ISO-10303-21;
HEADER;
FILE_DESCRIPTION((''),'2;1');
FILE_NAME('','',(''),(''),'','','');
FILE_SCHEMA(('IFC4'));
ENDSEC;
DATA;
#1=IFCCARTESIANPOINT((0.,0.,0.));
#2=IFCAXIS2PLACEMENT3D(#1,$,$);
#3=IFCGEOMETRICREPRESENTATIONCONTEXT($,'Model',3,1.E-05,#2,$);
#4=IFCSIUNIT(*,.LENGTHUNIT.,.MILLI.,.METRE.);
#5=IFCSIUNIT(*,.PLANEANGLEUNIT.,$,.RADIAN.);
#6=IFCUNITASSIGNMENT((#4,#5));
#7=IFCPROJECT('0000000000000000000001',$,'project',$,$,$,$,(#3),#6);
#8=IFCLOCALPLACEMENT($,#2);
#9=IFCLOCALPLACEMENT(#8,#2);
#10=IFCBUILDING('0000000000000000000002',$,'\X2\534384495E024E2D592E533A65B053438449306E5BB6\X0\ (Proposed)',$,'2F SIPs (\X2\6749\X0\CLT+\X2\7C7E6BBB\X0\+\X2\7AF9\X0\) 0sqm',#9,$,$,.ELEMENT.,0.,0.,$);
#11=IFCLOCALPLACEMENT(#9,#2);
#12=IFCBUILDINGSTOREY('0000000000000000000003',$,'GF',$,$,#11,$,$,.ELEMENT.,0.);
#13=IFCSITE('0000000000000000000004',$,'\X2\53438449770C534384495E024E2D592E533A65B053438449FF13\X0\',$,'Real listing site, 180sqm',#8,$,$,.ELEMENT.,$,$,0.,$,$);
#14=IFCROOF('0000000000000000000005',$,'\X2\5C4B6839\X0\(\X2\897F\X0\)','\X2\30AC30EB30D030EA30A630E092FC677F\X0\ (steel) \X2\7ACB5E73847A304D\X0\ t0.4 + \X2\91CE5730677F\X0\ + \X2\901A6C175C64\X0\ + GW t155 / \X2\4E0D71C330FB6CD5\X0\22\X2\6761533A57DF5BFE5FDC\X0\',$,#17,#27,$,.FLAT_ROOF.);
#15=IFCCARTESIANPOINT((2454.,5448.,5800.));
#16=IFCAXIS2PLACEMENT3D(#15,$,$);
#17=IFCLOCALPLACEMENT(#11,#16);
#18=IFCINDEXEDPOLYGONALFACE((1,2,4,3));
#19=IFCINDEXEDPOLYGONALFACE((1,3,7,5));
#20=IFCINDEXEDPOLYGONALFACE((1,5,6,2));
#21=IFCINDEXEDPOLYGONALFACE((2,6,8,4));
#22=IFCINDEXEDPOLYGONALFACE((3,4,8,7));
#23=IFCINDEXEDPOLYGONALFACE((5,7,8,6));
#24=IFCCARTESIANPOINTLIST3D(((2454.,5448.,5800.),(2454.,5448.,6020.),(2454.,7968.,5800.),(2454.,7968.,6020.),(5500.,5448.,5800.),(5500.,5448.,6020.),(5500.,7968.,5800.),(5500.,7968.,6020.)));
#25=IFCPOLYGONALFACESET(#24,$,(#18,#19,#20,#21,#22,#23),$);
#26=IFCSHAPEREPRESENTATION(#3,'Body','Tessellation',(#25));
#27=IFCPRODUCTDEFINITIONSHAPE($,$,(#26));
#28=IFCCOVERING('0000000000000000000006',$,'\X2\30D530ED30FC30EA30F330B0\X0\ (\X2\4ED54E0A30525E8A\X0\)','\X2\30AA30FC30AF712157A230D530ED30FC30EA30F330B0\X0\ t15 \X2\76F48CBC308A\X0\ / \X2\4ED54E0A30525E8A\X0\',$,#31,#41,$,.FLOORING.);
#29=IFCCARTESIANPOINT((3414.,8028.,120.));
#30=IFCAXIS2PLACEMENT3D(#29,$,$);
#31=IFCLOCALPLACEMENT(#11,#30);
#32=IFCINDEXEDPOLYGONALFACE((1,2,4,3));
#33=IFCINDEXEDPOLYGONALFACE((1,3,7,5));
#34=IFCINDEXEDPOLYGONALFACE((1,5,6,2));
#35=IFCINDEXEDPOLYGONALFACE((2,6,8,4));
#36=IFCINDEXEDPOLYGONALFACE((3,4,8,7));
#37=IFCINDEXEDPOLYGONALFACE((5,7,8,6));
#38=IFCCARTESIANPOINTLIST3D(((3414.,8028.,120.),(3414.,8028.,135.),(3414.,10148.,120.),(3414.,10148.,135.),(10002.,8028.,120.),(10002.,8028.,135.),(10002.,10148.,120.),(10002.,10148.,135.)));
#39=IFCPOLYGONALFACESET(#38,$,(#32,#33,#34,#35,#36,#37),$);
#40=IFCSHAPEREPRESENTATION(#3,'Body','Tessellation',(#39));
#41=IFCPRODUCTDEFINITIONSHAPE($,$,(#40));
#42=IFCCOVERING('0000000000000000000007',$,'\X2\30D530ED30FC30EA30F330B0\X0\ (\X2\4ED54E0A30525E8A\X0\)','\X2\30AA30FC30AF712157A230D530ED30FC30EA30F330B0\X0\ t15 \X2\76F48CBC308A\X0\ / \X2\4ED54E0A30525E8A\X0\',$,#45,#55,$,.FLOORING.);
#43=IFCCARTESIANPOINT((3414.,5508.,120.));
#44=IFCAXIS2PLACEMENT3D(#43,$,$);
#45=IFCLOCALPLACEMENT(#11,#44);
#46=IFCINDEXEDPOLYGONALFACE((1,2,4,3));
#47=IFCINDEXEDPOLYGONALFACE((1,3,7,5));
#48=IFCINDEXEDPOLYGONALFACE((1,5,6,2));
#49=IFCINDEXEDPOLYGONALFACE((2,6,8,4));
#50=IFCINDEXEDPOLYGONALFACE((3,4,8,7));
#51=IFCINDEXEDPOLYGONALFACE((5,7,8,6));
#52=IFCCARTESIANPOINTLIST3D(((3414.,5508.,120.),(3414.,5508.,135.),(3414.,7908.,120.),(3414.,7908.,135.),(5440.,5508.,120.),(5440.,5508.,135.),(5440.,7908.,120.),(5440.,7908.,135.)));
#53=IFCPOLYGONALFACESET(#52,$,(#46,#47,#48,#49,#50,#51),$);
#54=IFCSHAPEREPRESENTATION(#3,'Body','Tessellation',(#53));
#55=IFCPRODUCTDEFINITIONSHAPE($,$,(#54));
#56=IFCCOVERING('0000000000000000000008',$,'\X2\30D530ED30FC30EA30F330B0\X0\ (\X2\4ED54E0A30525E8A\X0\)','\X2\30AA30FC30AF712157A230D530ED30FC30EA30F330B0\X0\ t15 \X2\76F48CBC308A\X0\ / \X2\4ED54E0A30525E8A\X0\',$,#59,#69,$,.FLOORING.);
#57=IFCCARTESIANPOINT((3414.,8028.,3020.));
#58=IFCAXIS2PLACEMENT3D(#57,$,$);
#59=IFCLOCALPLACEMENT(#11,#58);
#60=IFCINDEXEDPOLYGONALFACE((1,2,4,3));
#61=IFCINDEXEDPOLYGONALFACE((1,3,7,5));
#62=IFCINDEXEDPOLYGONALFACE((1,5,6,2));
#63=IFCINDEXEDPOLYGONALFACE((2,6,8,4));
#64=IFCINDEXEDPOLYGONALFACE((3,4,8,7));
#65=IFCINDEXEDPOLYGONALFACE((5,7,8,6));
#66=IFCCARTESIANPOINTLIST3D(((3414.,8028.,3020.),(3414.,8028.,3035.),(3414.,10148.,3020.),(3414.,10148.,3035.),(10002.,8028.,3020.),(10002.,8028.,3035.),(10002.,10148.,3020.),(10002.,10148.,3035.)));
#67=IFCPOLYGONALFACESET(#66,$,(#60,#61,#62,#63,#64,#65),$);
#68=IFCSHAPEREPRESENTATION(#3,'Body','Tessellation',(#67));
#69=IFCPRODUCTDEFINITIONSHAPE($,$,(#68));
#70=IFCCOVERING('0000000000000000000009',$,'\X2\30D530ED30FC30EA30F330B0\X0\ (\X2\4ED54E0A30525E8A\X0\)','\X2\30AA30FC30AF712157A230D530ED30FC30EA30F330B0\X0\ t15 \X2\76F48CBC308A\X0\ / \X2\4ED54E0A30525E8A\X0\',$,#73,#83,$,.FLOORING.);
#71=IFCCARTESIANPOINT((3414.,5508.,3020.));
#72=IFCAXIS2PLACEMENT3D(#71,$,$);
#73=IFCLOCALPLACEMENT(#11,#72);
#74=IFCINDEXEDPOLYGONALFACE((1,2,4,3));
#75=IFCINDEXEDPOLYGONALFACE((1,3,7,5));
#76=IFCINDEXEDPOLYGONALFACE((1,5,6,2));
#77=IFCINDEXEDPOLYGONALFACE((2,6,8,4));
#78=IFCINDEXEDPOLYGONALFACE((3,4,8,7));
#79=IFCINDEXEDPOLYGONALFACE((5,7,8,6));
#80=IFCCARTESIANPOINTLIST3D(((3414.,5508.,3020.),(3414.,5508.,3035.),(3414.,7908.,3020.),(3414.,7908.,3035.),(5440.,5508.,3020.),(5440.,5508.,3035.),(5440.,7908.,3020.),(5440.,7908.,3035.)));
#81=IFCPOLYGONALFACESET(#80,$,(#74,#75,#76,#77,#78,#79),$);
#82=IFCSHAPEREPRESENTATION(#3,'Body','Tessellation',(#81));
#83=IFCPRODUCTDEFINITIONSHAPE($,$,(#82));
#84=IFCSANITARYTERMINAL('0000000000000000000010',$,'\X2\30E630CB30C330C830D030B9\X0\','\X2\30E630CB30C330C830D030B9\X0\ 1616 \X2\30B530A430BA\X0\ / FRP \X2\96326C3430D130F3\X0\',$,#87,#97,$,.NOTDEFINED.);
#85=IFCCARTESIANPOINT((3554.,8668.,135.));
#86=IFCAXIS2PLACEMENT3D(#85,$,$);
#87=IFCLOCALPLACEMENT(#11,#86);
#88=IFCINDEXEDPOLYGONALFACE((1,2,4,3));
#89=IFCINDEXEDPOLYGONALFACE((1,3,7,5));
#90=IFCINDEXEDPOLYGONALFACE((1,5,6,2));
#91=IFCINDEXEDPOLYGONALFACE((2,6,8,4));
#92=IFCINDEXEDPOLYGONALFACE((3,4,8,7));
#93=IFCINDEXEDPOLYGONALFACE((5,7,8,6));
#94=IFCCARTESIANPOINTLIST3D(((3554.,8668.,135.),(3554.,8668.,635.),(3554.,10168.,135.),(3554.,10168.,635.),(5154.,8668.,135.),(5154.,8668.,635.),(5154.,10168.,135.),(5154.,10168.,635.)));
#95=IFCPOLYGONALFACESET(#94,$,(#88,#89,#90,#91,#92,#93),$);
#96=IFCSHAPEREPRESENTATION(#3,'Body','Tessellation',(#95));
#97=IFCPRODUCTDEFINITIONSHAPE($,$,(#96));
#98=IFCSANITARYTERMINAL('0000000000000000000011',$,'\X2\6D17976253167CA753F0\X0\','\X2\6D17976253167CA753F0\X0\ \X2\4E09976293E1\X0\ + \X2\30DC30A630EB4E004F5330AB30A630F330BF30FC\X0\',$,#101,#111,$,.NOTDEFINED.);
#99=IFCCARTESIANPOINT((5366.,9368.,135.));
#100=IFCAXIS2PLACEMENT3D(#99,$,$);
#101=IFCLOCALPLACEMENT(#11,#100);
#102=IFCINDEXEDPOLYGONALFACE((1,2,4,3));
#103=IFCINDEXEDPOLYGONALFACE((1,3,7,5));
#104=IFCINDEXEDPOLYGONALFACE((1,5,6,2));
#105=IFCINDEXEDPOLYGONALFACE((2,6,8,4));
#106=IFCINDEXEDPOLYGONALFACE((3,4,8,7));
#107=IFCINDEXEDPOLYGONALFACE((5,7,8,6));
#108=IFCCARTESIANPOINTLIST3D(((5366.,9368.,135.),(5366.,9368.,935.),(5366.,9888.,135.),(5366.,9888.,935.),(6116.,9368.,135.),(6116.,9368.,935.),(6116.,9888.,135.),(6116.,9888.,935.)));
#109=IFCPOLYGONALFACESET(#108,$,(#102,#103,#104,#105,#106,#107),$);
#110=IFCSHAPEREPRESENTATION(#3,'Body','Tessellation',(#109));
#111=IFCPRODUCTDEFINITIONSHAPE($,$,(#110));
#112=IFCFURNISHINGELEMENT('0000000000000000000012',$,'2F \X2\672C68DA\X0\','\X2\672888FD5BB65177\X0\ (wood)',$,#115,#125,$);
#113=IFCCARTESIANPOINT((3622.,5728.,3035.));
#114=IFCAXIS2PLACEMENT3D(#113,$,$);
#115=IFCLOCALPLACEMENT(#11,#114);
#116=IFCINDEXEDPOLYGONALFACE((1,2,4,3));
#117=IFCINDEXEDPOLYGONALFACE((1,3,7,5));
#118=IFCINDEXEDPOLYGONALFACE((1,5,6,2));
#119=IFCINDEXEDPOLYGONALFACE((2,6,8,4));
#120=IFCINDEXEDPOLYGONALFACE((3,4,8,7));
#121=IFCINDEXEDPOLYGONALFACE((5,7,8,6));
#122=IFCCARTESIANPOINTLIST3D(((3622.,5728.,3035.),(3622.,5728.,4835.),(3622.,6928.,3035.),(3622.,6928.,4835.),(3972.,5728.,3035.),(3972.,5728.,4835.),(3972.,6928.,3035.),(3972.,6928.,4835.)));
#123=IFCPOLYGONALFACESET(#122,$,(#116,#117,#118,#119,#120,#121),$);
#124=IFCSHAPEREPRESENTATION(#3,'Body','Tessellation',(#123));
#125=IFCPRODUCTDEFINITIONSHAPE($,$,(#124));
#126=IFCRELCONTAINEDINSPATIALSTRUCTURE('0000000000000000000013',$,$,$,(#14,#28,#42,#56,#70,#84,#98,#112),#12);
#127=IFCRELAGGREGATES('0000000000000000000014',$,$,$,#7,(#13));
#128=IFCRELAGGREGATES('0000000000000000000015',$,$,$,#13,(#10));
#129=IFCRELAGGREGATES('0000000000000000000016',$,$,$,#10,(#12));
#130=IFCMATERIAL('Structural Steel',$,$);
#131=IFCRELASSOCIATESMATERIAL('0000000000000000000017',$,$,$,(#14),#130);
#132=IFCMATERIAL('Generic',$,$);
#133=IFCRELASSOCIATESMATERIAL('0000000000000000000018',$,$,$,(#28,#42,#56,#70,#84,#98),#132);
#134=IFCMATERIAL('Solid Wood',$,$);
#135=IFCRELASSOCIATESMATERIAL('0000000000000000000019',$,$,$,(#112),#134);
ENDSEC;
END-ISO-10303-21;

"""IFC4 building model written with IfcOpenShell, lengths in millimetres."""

from ifc_helpers import new_model, si_unit, frame, frame_2d, origin, place, context, project, spatial, rectangle, extrude, material, element, save


model = new_model("IFC4")

# Units and contexts
model_context = context("Model", 3, precision=1e-05, world=origin())
ifc_project = project(units=[si_unit("LENGTHUNIT", "METRE", prefix="MILLI"), si_unit("PLANEANGLEUNIT", "RADIAN")], contexts=[model_context])

# Site, building, storey
site_placement = place(None, origin())
site = spatial("IfcSite", under=ifc_project, at=site_placement, Name="千葉県千葉市中央区新千葉３", ObjectType="Real listing site, 180sqm", CompositionType="ELEMENT", RefElevation=0.0)
building_placement = place(site_placement, origin())
building = spatial("IfcBuilding", under=site, at=building_placement, Name="千葉市中央区新千葉の家 (Proposed)", ObjectType="2F SIPs (杉CLT+籾殻+竹) 0sqm", CompositionType="ELEMENT", ElevationOfRefHeight=0.0, ElevationOfTerrain=0.0)
storey_placement = place(building_placement, origin())
storey = spatial("IfcBuildingStorey", under=building, at=storey_placement, Name="GF", CompositionType="ELEMENT", Elevation=0.0)

# Shared definitions
ifc_material_1 = material(Name="Solid Wood")

# Roof
ifc_material_2 = material(Name="Structural Steel")
roof_placement = place(storey_placement, frame((2454.0, 5448.0, 5800.0)))
element("IfcRoof", 1, at=roof_placement, inside=storey, material=ifc_material_2, Name="屋根(西)", Description="ガルバリウム鋼板 (steel) 立平葺き t0.4 + 野地板 + 通気層 + GW t155 / 不燃・法22条区域対応", PredefinedType="FLAT_ROOF", context=model_context, shape_type="SweptSolid", body=[
    extrude(rectangle(XDim=3046.0, YDim=2520.0, at=frame_2d((1523.0, 1260.0))), frame((2454.0, 5448.0, 5800.0)), (0.0, 0.0, 1.0), 220.0),
])

# Coverings
ifc_material_3 = material(Name="Generic")
covering_1_placement = place(storey_placement, frame((3414.0, 8028.0, 120.0)))
element("IfcCovering", 2, at=covering_1_placement, inside=storey, material=ifc_material_3, Name="フローリング (仕上げ床)", Description="オーク無垢フローリング t15 直貼り / 仕上げ床", PredefinedType="FLOORING", context=model_context, shape_type="SweptSolid", body=[
    extrude(rectangle(XDim=6588.0, YDim=2120.0, at=frame_2d((3294.0, 1060.0))), frame((3414.0, 8028.0, 120.0)), (0.0, 0.0, 1.0), 15.0),
])
covering_2_placement = place(storey_placement, frame((3414.0, 5508.0, 120.0)))
element("IfcCovering", 3, at=covering_2_placement, inside=storey, material=ifc_material_3, Name="フローリング (仕上げ床)", Description="オーク無垢フローリング t15 直貼り / 仕上げ床", PredefinedType="FLOORING", context=model_context, shape_type="SweptSolid", body=[
    extrude(rectangle(XDim=2026.0, YDim=2400.0, at=frame_2d((1013.0, 1200.0))), frame((3414.0, 5508.0, 120.0)), (0.0, 0.0, 1.0), 15.0),
])
covering_3_placement = place(storey_placement, frame((3414.0, 8028.0, 3020.0)))
element("IfcCovering", 4, at=covering_3_placement, inside=storey, material=ifc_material_3, Name="フローリング (仕上げ床)", Description="オーク無垢フローリング t15 直貼り / 仕上げ床", PredefinedType="FLOORING", context=model_context, shape_type="SweptSolid", body=[
    extrude(rectangle(XDim=6588.0, YDim=2120.0, at=frame_2d((3294.0, 1060.0))), frame((3414.0, 8028.0, 3020.0)), (0.0, 0.0, 1.0), 15.0),
])
covering_4_placement = place(storey_placement, frame((3414.0, 5508.0, 3020.0)))
element("IfcCovering", 5, at=covering_4_placement, inside=storey, material=ifc_material_3, Name="フローリング (仕上げ床)", Description="オーク無垢フローリング t15 直貼り / 仕上げ床", PredefinedType="FLOORING", context=model_context, shape_type="SweptSolid", body=[
    extrude(rectangle(XDim=2026.0, YDim=2400.0, at=frame_2d((1013.0, 1200.0))), frame((3414.0, 5508.0, 3020.0)), (0.0, 0.0, 1.0), 15.0),
])

# Sanitary terminals
sanitary_terminal_1_placement = place(storey_placement, frame((3554.0, 8668.0, 135.0)))
element("IfcSanitaryTerminal", 6, at=sanitary_terminal_1_placement, inside=storey, material=ifc_material_3, Name="ユニットバス", Description="ユニットバス 1616 サイズ / FRP 防水パン", PredefinedType="NOTDEFINED", context=model_context, shape_type="SweptSolid", body=[
    extrude(rectangle(XDim=1600.0, YDim=1500.0, at=frame_2d((800.0, 750.0))), frame((3554.0, 8668.0, 135.0)), (0.0, 0.0, 1.0), 500.0),
])
sanitary_terminal_2_placement = place(storey_placement, frame((5366.0, 9368.0, 135.0)))
element("IfcSanitaryTerminal", 7, at=sanitary_terminal_2_placement, inside=storey, material=ifc_material_3, Name="洗面化粧台", Description="洗面化粧台 三面鏡 + ボウル一体カウンター", PredefinedType="NOTDEFINED", context=model_context, shape_type="SweptSolid", body=[
    extrude(rectangle(XDim=750.0, YDim=520.0, at=frame_2d((375.0, 260.0))), frame((5366.0, 9368.0, 135.0)), (0.0, 0.0, 1.0), 800.0),
])

# Furnishing element
furnishing_placement = place(storey_placement, frame((3622.0, 5728.0, 3035.0)))
element("IfcFurnishingElement", 8, at=furnishing_placement, inside=storey, material=ifc_material_1, Name="2F 本棚", Description="木製家具 (wood)", context=model_context, shape_type="SweptSolid", body=[
    extrude(rectangle(XDim=350.0, YDim=1200.0, at=frame_2d((175.0, 600.0))), frame((3622.0, 5728.0, 3035.0)), (0.0, 0.0, 1.0), 1800.0),
])

save(model, "model.ifc")
